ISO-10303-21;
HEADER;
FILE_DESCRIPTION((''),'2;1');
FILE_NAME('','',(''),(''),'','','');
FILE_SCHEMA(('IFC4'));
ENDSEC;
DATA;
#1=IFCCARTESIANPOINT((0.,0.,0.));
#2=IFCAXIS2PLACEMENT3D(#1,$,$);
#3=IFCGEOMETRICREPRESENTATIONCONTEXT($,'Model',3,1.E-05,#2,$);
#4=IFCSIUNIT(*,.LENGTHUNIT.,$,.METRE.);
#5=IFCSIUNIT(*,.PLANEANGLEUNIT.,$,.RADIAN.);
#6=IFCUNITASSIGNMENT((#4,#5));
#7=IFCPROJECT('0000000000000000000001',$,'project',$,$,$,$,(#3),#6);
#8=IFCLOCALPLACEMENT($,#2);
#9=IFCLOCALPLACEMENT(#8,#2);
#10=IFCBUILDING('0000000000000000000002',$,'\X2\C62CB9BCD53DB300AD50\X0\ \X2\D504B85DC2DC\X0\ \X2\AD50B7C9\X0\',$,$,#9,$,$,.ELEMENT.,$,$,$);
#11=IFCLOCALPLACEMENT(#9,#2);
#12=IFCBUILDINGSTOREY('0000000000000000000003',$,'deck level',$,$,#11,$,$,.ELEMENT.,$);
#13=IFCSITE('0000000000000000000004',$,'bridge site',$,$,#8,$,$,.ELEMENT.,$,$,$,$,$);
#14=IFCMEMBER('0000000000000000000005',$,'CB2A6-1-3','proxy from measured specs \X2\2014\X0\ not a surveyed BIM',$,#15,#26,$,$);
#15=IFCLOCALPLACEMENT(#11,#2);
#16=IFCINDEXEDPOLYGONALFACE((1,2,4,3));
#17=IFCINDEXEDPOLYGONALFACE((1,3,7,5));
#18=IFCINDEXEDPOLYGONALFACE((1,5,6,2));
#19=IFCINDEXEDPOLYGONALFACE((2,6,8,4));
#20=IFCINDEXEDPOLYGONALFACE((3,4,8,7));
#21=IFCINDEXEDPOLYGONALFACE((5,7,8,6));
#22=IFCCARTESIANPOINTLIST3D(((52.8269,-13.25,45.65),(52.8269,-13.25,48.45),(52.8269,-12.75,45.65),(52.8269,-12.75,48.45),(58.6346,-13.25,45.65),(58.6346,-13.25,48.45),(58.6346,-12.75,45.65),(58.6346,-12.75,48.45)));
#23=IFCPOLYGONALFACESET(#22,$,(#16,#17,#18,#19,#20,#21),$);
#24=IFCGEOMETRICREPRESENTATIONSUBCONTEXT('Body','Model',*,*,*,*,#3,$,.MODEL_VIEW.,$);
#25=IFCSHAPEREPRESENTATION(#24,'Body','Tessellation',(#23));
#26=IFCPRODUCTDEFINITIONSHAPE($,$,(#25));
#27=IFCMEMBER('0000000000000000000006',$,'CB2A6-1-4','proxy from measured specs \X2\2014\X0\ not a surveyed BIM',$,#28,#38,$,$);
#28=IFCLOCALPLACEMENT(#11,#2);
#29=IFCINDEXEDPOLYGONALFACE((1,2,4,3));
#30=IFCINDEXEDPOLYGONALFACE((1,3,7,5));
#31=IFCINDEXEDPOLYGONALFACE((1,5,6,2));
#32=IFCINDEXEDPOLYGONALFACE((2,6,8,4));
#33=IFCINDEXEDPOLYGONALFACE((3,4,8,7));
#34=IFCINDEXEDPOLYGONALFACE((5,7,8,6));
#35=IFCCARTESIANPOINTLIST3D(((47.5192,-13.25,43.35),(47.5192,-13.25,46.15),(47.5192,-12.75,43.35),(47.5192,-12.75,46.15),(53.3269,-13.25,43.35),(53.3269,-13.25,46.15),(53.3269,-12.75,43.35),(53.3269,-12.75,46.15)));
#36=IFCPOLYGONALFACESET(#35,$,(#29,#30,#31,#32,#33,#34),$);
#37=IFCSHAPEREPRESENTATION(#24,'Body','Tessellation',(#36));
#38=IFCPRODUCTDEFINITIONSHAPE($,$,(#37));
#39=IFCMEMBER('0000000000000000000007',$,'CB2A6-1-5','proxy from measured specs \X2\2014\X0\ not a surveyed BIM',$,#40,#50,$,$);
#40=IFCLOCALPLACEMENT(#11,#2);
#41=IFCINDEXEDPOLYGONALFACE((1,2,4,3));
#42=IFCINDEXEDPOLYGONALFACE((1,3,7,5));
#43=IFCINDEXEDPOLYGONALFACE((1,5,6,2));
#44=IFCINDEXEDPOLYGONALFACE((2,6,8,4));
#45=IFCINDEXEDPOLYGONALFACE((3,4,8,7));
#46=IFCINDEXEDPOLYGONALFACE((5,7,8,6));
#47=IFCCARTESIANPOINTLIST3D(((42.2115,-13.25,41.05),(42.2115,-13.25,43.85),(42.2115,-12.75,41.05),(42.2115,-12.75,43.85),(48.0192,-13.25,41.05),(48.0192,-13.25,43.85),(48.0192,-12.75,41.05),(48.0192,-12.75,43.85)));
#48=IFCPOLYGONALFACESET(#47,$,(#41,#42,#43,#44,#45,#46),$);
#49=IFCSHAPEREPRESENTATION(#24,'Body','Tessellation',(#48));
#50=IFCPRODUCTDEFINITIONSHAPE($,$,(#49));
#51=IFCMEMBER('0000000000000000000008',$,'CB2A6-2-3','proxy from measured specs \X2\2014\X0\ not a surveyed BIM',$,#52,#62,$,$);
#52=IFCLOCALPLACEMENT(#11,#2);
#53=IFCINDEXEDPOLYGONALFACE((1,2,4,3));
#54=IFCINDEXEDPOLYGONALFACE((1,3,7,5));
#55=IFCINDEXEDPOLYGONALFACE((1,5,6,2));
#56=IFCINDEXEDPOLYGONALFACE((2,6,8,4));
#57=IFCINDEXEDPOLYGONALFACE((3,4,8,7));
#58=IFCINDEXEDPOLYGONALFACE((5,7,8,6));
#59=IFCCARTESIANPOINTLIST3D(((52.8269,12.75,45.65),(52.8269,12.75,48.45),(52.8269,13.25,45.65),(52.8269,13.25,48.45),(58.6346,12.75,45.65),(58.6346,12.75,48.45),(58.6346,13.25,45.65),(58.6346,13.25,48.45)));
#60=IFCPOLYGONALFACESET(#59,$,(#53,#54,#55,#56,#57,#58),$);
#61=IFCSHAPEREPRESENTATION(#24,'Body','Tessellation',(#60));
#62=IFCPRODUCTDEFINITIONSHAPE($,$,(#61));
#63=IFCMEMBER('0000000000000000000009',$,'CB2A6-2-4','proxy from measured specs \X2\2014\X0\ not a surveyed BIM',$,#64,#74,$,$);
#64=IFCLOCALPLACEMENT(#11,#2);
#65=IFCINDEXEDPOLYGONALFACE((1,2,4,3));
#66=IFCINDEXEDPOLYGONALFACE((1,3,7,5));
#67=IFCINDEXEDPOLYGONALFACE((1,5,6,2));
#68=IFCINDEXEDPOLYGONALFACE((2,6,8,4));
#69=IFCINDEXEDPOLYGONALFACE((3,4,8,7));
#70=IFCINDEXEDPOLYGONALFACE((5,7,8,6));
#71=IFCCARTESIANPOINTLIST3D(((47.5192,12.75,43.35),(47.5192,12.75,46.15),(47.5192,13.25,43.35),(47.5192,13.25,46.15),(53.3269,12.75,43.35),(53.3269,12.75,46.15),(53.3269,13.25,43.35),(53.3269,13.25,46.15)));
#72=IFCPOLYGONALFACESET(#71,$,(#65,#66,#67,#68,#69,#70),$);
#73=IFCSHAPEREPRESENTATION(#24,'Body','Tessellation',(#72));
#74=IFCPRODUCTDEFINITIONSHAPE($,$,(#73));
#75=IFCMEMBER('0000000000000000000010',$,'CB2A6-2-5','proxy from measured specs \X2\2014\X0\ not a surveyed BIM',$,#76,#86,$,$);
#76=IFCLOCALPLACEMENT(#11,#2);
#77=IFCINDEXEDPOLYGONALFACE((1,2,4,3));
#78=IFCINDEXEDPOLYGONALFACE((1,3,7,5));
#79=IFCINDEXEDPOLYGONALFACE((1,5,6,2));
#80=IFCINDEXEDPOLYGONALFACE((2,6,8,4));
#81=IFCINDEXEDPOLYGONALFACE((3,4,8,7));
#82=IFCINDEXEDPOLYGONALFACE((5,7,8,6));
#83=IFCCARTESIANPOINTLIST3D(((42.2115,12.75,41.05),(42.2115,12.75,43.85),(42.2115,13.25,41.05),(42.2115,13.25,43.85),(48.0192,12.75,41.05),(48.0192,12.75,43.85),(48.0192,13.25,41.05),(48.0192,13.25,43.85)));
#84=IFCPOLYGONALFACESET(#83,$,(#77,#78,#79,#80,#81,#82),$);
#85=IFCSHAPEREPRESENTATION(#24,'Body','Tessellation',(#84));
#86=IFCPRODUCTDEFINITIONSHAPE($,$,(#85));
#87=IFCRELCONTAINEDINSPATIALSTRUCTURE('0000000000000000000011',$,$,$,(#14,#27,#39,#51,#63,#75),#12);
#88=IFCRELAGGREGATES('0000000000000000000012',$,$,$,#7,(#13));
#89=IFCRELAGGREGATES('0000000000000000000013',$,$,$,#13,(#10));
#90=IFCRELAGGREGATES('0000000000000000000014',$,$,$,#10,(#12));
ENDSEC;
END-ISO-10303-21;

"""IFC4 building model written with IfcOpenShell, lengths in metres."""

from ifc_helpers import new_model, si_unit, frame, origin, origin_2d, place, context, subcontext, project, spatial, rectangle, extrude, element, save


model = new_model("IFC4")

# Units and contexts
model_context = context("Model", 3, precision=1e-05, world=origin())
body_context = subcontext(model_context, "Body", "Model", "MODEL_VIEW")
ifc_project = project(units=[si_unit("LENGTHUNIT", "METRE"), si_unit("PLANEANGLEUNIT", "RADIAN")], contexts=[model_context])

# Site, building, storey
site_placement = place(None, origin())
site = spatial("IfcSite", under=ifc_project, at=site_placement, Name="bridge site", CompositionType="ELEMENT")
building_placement = place(site_placement, origin())
building = spatial("IfcBuilding", under=site, at=building_placement, Name="올림픽대교 프록시 교량", CompositionType="ELEMENT")
storey_placement = place(building_placement, origin())
storey = spatial("IfcBuildingStorey", under=building, at=storey_placement, Name="deck level", CompositionType="ELEMENT")

# Members
member_1_placement = place(storey_placement, frame((55.7308, -13.0, 45.65)))
element("IfcMember", 1, at=member_1_placement, inside=storey, Name="CB2A6-1-3", Description="proxy from measured specs — not a surveyed BIM", context=body_context, shape_type="SweptSolid", body=[
    extrude(rectangle(XDim=5.8077, YDim=0.5, at=origin_2d()), origin(), (0.0, 0.0, 1.0), 2.8),
])
member_2_placement = place(storey_placement, frame((50.4231, -13.0, 43.35)))
element("IfcMember", 2, at=member_2_placement, inside=storey, Name="CB2A6-1-4", Description="proxy from measured specs — not a surveyed BIM", context=body_context, shape_type="SweptSolid", body=[
    extrude(rectangle(XDim=5.8077, YDim=0.5, at=origin_2d()), origin(), (0.0, 0.0, 1.0), 2.8),
])
member_3_placement = place(storey_placement, frame((45.1154, -13.0, 41.05)))
element("IfcMember", 3, at=member_3_placement, inside=storey, Name="CB2A6-1-5", Description="proxy from measured specs — not a surveyed BIM", context=body_context, shape_type="SweptSolid", body=[
    extrude(rectangle(XDim=5.8077, YDim=0.5, at=origin_2d()), origin(), (0.0, 0.0, 1.0), 2.8),
])
member_4_placement = place(storey_placement, frame((55.7308, 13.0, 45.65)))
element("IfcMember", 4, at=member_4_placement, inside=storey, Name="CB2A6-2-3", Description="proxy from measured specs — not a surveyed BIM", context=body_context, shape_type="SweptSolid", body=[
    extrude(rectangle(XDim=5.8077, YDim=0.5, at=origin_2d()), origin(), (0.0, 0.0, 1.0), 2.8),
])
member_5_placement = place(storey_placement, frame((50.4231, 13.0, 43.35)))
element("IfcMember", 5, at=member_5_placement, inside=storey, Name="CB2A6-2-4", Description="proxy from measured specs — not a surveyed BIM", context=body_context, shape_type="SweptSolid", body=[
    extrude(rectangle(XDim=5.8077, YDim=0.5, at=origin_2d()), origin(), (0.0, 0.0, 1.0), 2.8),
])
member_6_placement = place(storey_placement, frame((45.1154, 13.0, 41.05)))
element("IfcMember", 6, at=member_6_placement, inside=storey, Name="CB2A6-2-5", Description="proxy from measured specs — not a surveyed BIM", context=body_context, shape_type="SweptSolid", body=[
    extrude(rectangle(XDim=5.8077, YDim=0.5, at=origin_2d()), origin(), (0.0, 0.0, 1.0), 2.8),
])

save(model, "model.ifc")
